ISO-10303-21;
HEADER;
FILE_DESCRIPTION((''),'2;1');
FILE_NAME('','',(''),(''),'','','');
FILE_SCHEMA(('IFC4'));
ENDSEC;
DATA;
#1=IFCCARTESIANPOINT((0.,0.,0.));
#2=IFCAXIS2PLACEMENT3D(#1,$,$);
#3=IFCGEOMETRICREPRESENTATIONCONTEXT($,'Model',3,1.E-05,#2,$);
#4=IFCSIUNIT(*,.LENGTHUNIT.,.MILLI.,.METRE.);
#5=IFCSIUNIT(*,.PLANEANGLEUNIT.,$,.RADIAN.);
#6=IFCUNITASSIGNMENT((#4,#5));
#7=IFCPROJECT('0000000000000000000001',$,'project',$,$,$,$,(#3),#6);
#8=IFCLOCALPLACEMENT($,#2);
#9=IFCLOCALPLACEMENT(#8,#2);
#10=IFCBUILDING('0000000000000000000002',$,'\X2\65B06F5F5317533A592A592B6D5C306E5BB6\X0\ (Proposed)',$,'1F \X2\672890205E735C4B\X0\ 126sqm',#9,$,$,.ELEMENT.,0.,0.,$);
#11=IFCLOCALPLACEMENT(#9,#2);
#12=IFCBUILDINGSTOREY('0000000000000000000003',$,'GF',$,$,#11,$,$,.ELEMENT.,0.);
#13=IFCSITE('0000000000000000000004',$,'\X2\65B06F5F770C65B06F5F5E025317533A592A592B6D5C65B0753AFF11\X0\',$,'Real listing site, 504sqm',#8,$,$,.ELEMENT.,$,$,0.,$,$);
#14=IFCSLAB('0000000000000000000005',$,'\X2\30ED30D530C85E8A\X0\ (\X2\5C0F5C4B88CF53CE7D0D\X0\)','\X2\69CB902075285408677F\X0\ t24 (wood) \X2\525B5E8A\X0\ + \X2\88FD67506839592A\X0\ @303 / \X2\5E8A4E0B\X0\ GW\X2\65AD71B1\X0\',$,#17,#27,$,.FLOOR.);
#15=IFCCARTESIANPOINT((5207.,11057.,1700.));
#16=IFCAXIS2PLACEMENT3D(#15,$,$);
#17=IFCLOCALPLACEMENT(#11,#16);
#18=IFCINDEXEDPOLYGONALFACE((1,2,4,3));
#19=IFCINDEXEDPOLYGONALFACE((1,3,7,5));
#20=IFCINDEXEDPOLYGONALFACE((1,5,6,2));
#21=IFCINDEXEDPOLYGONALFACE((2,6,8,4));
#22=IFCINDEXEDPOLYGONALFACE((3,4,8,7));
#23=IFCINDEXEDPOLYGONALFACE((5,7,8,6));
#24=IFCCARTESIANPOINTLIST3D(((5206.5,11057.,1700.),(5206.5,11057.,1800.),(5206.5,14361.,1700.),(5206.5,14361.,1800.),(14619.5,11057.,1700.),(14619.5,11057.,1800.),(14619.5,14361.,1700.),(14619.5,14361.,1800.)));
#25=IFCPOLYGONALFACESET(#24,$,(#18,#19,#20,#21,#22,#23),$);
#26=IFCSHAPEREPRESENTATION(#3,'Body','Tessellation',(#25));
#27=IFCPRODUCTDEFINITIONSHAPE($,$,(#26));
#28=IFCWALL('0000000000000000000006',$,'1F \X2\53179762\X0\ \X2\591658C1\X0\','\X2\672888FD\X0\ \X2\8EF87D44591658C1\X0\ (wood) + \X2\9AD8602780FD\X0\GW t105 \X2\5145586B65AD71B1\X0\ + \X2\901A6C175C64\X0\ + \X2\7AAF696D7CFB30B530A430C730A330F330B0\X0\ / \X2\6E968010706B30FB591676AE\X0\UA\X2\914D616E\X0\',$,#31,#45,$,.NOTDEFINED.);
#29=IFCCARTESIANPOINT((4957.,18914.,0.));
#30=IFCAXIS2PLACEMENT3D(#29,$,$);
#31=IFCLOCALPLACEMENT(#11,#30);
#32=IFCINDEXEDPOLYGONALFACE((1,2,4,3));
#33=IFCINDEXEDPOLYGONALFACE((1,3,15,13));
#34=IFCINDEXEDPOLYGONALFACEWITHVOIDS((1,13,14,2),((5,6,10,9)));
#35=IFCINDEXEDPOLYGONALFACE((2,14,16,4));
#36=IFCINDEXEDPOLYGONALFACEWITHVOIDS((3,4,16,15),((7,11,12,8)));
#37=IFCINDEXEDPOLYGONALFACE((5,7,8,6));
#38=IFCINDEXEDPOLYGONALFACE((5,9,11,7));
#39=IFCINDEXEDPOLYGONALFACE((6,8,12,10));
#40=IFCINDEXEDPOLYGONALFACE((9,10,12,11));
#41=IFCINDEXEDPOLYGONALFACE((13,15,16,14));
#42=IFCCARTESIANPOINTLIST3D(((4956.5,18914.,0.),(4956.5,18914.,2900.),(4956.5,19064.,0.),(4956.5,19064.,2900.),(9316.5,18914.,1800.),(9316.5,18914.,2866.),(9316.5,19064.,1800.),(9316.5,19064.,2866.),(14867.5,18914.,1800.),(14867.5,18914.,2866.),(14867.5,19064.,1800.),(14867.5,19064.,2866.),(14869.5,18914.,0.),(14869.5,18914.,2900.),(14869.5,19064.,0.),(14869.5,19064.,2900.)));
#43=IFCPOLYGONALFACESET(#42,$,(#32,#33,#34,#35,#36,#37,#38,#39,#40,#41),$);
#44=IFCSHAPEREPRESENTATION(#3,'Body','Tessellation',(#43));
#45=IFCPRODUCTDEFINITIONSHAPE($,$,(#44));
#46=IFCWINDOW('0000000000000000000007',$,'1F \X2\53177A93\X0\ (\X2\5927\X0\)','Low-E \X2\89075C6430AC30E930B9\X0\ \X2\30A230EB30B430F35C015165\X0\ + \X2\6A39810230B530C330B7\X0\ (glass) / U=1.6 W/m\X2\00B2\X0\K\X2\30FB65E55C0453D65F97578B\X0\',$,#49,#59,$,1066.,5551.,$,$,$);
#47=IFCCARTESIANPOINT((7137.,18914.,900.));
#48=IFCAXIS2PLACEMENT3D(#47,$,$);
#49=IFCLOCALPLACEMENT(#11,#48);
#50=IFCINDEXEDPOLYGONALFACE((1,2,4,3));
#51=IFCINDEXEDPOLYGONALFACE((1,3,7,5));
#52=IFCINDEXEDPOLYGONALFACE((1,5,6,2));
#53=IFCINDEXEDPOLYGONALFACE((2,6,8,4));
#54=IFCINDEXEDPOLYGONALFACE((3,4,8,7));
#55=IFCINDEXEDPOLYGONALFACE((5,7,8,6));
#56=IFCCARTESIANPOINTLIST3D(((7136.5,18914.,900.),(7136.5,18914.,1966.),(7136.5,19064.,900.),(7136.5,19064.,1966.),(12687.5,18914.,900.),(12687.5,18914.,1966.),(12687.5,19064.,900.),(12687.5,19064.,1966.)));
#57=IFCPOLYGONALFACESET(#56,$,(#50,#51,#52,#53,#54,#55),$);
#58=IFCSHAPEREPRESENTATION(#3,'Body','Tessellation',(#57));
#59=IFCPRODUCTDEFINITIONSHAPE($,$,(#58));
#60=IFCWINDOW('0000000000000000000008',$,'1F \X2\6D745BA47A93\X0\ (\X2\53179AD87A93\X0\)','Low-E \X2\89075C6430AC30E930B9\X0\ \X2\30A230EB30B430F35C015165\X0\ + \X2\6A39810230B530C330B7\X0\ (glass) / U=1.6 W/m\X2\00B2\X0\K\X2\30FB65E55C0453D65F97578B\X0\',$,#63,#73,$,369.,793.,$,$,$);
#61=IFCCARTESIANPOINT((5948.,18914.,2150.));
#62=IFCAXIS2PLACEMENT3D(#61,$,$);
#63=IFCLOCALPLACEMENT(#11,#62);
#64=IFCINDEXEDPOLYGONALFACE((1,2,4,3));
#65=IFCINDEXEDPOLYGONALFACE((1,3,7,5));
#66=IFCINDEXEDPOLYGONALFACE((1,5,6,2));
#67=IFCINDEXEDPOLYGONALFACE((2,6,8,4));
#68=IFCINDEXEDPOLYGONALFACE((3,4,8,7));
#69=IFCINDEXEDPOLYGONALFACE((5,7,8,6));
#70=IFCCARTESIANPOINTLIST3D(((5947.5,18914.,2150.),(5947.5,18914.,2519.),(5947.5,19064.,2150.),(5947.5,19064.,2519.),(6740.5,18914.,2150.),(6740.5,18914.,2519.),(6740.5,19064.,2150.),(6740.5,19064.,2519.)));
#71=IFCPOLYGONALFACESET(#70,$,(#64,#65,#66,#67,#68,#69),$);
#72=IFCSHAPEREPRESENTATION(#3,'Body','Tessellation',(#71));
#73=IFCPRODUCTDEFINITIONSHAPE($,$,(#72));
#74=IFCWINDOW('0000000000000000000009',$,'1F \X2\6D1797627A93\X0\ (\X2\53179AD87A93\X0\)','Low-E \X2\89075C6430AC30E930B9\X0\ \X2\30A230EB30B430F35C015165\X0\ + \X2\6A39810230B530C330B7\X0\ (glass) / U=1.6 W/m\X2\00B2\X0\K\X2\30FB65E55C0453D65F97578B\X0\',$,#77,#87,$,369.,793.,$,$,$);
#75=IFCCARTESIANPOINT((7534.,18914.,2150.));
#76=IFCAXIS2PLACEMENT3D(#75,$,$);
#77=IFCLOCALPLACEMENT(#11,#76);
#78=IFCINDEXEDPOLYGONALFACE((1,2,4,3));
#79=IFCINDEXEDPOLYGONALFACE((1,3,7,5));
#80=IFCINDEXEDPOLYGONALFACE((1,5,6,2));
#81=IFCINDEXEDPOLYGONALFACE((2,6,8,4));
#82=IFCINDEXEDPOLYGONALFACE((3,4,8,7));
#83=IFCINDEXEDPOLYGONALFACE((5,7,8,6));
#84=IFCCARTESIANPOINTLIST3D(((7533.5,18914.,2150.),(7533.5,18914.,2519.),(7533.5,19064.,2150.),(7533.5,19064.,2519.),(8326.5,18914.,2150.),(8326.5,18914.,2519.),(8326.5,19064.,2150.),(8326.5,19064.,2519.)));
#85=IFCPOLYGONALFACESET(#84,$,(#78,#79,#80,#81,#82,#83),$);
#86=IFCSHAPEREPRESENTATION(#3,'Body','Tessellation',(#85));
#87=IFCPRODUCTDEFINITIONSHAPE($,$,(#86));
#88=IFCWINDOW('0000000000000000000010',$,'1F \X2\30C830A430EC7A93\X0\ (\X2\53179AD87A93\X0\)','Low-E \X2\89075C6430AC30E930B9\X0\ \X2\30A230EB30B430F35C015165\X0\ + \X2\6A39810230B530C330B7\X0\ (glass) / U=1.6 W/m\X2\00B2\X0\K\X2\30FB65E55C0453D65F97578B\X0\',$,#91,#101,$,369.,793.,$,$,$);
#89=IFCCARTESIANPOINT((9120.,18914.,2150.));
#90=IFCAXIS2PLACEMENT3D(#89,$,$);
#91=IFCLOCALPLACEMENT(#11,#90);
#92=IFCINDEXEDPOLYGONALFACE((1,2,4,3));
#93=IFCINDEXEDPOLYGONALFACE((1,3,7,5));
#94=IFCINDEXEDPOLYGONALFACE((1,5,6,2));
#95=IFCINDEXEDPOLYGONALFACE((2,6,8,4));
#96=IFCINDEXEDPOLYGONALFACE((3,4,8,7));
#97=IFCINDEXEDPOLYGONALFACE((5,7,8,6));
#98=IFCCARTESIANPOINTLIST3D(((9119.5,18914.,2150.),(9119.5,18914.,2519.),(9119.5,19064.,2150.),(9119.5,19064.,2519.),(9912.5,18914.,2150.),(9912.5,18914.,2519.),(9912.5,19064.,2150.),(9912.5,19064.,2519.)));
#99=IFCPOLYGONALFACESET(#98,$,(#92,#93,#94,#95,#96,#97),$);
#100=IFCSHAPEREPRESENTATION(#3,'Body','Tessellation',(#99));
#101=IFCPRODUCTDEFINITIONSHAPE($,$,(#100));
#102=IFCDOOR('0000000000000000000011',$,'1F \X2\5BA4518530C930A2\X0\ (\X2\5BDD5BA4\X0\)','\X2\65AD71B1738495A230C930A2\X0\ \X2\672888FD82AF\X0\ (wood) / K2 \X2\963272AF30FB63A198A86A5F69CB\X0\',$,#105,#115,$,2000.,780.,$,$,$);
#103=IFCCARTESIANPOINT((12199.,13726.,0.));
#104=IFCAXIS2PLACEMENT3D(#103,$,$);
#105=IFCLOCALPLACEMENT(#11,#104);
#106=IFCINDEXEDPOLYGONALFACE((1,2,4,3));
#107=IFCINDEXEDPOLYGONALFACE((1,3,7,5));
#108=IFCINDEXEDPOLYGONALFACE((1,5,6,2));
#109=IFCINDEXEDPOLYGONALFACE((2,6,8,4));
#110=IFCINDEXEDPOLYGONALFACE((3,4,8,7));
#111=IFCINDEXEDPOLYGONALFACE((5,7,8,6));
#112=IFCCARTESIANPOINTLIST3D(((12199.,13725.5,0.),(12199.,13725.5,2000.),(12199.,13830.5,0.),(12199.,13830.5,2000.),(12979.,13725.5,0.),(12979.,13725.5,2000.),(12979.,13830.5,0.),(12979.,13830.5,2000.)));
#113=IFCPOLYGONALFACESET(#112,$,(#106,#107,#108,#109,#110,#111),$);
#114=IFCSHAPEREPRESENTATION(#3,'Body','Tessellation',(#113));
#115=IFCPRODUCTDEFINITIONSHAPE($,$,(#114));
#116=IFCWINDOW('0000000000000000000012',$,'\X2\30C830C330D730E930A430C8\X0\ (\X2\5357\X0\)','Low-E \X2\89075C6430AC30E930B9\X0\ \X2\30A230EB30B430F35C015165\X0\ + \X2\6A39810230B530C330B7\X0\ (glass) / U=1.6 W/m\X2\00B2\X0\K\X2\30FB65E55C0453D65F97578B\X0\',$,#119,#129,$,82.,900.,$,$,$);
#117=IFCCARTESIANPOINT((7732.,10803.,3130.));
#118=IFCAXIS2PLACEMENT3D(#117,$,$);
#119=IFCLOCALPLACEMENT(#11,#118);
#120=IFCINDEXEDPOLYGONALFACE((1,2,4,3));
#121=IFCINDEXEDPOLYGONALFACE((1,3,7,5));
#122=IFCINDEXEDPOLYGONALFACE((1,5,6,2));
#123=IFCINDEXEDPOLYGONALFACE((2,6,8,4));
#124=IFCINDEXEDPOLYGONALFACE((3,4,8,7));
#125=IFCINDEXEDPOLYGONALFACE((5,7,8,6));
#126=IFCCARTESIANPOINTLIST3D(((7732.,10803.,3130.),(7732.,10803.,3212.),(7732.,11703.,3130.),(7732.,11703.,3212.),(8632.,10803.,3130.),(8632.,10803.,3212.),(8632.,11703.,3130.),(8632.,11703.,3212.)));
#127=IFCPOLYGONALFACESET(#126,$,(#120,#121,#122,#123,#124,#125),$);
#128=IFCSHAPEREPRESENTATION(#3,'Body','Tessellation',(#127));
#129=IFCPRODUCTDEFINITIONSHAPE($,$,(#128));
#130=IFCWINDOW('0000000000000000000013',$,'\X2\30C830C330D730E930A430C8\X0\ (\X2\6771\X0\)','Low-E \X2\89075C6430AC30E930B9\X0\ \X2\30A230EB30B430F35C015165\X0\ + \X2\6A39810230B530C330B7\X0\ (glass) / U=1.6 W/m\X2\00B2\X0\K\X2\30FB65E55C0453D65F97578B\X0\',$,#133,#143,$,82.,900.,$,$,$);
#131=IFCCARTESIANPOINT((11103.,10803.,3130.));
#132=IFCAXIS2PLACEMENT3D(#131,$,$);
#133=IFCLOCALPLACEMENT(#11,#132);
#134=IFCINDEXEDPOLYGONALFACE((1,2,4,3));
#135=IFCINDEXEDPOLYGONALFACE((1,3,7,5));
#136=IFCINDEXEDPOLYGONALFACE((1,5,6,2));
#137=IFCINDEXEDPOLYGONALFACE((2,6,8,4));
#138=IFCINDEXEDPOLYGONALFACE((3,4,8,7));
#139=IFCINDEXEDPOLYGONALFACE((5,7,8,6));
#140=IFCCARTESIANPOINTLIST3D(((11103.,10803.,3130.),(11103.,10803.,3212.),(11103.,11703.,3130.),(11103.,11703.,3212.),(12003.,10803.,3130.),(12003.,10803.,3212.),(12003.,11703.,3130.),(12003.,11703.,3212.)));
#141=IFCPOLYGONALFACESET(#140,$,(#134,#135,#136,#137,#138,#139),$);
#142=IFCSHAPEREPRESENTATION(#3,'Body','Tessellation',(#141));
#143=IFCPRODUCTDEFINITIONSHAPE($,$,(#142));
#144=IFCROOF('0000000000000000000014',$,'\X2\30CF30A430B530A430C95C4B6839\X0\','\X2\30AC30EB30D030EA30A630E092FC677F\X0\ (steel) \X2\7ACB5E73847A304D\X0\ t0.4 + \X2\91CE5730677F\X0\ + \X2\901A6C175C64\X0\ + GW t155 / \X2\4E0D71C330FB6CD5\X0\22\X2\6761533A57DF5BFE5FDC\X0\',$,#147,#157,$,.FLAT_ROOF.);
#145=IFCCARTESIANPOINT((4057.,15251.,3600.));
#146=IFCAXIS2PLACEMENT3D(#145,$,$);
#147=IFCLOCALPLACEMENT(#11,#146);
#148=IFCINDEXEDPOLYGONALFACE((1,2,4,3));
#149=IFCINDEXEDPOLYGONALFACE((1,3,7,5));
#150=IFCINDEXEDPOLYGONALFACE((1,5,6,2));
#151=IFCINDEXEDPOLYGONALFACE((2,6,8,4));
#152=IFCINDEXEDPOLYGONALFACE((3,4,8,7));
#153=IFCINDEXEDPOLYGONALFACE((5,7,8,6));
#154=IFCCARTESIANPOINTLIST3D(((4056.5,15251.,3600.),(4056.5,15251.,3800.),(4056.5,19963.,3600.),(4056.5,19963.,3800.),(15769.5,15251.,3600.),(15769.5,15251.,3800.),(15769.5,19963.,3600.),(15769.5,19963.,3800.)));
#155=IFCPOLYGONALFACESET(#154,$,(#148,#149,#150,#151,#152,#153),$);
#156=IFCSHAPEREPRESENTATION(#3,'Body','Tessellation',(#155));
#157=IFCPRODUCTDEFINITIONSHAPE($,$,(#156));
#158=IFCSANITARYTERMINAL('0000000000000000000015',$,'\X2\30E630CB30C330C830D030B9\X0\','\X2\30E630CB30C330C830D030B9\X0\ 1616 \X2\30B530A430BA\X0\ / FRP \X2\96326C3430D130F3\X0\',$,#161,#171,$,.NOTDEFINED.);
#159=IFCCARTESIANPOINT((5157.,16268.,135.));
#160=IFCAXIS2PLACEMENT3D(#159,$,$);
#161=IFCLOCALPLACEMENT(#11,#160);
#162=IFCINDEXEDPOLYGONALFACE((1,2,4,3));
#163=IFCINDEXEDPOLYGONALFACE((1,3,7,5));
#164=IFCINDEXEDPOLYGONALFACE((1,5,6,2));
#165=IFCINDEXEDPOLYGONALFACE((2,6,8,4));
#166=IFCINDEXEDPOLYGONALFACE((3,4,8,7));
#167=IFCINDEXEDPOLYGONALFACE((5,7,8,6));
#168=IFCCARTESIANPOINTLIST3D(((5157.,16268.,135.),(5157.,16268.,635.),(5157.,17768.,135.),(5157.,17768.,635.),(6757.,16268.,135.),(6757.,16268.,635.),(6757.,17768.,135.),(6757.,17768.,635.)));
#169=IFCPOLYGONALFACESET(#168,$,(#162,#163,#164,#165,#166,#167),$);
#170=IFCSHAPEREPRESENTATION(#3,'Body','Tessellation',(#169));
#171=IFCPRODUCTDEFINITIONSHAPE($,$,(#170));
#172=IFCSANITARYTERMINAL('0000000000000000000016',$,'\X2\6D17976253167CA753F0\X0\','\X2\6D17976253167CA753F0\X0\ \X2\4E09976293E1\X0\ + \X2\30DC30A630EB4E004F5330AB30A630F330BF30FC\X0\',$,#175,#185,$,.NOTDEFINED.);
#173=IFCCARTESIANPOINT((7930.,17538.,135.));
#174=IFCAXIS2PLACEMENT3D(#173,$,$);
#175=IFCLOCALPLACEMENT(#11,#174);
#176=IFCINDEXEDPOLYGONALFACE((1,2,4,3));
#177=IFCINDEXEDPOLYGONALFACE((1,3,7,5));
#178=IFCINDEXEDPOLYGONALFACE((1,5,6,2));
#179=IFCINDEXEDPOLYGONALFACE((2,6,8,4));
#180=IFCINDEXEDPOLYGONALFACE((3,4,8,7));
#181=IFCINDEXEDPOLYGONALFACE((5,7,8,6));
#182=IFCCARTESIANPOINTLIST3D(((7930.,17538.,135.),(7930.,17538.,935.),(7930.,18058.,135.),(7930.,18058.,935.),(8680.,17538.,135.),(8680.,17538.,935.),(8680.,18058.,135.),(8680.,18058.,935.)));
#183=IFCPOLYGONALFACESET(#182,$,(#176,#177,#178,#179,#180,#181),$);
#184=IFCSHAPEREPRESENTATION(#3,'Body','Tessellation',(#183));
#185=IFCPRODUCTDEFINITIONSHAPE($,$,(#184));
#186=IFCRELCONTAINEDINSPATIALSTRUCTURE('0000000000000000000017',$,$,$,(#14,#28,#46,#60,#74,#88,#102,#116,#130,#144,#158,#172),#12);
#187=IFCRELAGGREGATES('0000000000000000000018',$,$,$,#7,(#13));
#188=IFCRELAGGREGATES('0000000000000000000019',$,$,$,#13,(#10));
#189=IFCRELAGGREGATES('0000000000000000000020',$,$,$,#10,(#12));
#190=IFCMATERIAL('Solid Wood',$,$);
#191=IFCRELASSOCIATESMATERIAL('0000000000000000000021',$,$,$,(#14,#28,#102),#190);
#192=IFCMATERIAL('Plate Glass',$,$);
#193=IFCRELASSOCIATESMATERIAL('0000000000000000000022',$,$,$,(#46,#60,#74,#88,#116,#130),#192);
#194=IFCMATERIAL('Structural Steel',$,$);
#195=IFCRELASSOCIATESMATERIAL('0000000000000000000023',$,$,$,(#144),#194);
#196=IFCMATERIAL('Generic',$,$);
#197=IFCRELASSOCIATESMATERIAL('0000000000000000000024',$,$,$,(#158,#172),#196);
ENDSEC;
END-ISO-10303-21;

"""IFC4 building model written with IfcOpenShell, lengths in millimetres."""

from ifc_helpers import new_model, si_unit, frame, frame_2d, origin, place, context, project, spatial, rectangle, extrude, material, element, fill, save


model = new_model("IFC4")

# Units and contexts
model_context = context("Model", 3, precision=1e-05, world=origin())
ifc_project = project(units=[si_unit("LENGTHUNIT", "METRE", prefix="MILLI"), si_unit("PLANEANGLEUNIT", "RADIAN")], contexts=[model_context])

# Site, building, storey
site_placement = place(None, origin())
site = spatial("IfcSite", under=ifc_project, at=site_placement, Name="新潟県新潟市北区太夫浜新町１", ObjectType="Real listing site, 504sqm", CompositionType="ELEMENT", RefElevation=0.0)
building_placement = place(site_placement, origin())
building = spatial("IfcBuilding", under=site, at=building_placement, Name="新潟北区太夫浜の家 (Proposed)", ObjectType="1F 木造平屋 126sqm", CompositionType="ELEMENT", ElevationOfRefHeight=0.0, ElevationOfTerrain=0.0)
storey_placement = place(building_placement, origin())
storey = spatial("IfcBuildingStorey", under=building, at=storey_placement, Name="GF", CompositionType="ELEMENT", Elevation=0.0)

# Slab
ifc_material_1 = material(Name="Solid Wood")
slab_placement = place(storey_placement, frame((5207.0, 11057.0, 1700.0)))
element("IfcSlab", 1, at=slab_placement, inside=storey, material=ifc_material_1, Name="ロフト床 (小屋裏収納)", Description="構造用合板 t24 (wood) 剛床 + 製材根太 @303 / 床下 GW断熱", PredefinedType="FLOOR", context=model_context, shape_type="SweptSolid", body=[
    extrude(rectangle(XDim=9413.0, YDim=3304.0, at=frame_2d((4706.0, 1652.0))), frame((5207.0, 11057.0, 1700.0)), (0.0, 0.0, 1.0), 100.0),
])

# Wall, openings, windows
wall_1_placement = place(storey_placement, frame((4957.0, 18914.0, 0.0)))
wall_1 = element("IfcWall", 2, at=wall_1_placement, inside=storey, material=ifc_material_1, Name="1F 北面 外壁", Description="木製 軸組外壁 (wood) + 高性能GW t105 充填断熱 + 通気層 + 窯業系サイディング / 準耐火・外皮UA配慮", PredefinedType="NOTDEFINED", context=model_context, shape_type="SweptSolid", body=[
    extrude(rectangle(XDim=9913.0, YDim=150.0, at=frame_2d((4956.0, 75.0))), frame((4957.0, 18914.0, 0.0)), (0.0, 0.0, 1.0), 2900.0),
])
opening_1_placement = place(storey_placement, frame((7137.0, 18914.0, 900.0)))
opening_1 = element("IfcOpeningElement", 3, at=opening_1_placement, cuts=wall_1, PredefinedType="NOTDEFINED", context=model_context, shape_type="SweptSolid", body=[
    extrude(rectangle(XDim=5551.0, YDim=150.0, at=frame_2d((2775.0, 75.0))), frame((7137.0, 18914.0, 900.0)), (0.0, 0.0, 1.0), 1066.0),
])
opening_2_placement = place(storey_placement, frame((5948.0, 18914.0, 2150.0)))
opening_2 = element("IfcOpeningElement", 4, at=opening_2_placement, cuts=wall_1, PredefinedType="NOTDEFINED", context=model_context, shape_type="SweptSolid", body=[
    extrude(rectangle(XDim=793.0, YDim=150.0, at=frame_2d((396.0, 75.0))), frame((5948.0, 18914.0, 2150.0)), (0.0, 0.0, 1.0), 369.0),
])
opening_3_placement = place(storey_placement, frame((7534.0, 18914.0, 2150.0)))
opening_3 = element("IfcOpeningElement", 5, at=opening_3_placement, cuts=wall_1, PredefinedType="NOTDEFINED", context=model_context, shape_type="SweptSolid", body=[
    extrude(rectangle(XDim=793.0, YDim=150.0, at=frame_2d((396.0, 75.0))), frame((7534.0, 18914.0, 2150.0)), (0.0, 0.0, 1.0), 369.0),
])
opening_4_placement = place(storey_placement, frame((9120.0, 18914.0, 2150.0)))
opening_4 = element("IfcOpeningElement", 6, at=opening_4_placement, cuts=wall_1, PredefinedType="NOTDEFINED", context=model_context, shape_type="SweptSolid", body=[
    extrude(rectangle(XDim=793.0, YDim=150.0, at=frame_2d((396.0, 75.0))), frame((9120.0, 18914.0, 2150.0)), (0.0, 0.0, 1.0), 369.0),
])
ifc_material_2 = material(Name="Plate Glass")
window_1_placement = place(storey_placement, frame((7137.0, 18914.0, 900.0)))
window_1 = element("IfcWindow", 7, at=window_1_placement, inside=storey, material=ifc_material_2, Name="1F 北窓 (大)", Description="Low-E 複層ガラス アルゴン封入 + 樹脂サッシ (glass) / U=1.6 W/m²K・日射取得型", OverallHeight=1066.0, OverallWidth=5551.0, context=model_context, shape_type="SweptSolid", body=[
    extrude(rectangle(XDim=5551.0, YDim=150.0, at=frame_2d((2775.0, 75.0))), frame((7137.0, 18914.0, 900.0)), (0.0, 0.0, 1.0), 1066.0),
])
fill(opening_1, window_1)
window_2_placement = place(storey_placement, frame((5948.0, 18914.0, 2150.0)))
window_2 = element("IfcWindow", 8, at=window_2_placement, inside=storey, material=ifc_material_2, Name="1F 浴室窓 (北高窓)", Description="Low-E 複層ガラス アルゴン封入 + 樹脂サッシ (glass) / U=1.6 W/m²K・日射取得型", OverallHeight=369.0, OverallWidth=793.0, context=model_context, shape_type="SweptSolid", body=[
    extrude(rectangle(XDim=793.0, YDim=150.0, at=frame_2d((396.0, 75.0))), frame((5948.0, 18914.0, 2150.0)), (0.0, 0.0, 1.0), 369.0),
])
fill(opening_2, window_2)
window_3_placement = place(storey_placement, frame((7534.0, 18914.0, 2150.0)))
window_3 = element("IfcWindow", 9, at=window_3_placement, inside=storey, material=ifc_material_2, Name="1F 洗面窓 (北高窓)", Description="Low-E 複層ガラス アルゴン封入 + 樹脂サッシ (glass) / U=1.6 W/m²K・日射取得型", OverallHeight=369.0, OverallWidth=793.0, context=model_context, shape_type="SweptSolid", body=[
    extrude(rectangle(XDim=793.0, YDim=150.0, at=frame_2d((396.0, 75.0))), frame((7534.0, 18914.0, 2150.0)), (0.0, 0.0, 1.0), 369.0),
])
fill(opening_3, window_3)
window_4_placement = place(storey_placement, frame((9120.0, 18914.0, 2150.0)))
window_4 = element("IfcWindow", 10, at=window_4_placement, inside=storey, material=ifc_material_2, Name="1F トイレ窓 (北高窓)", Description="Low-E 複層ガラス アルゴン封入 + 樹脂サッシ (glass) / U=1.6 W/m²K・日射取得型", OverallHeight=369.0, OverallWidth=793.0, context=model_context, shape_type="SweptSolid", body=[
    extrude(rectangle(XDim=793.0, YDim=150.0, at=frame_2d((396.0, 75.0))), frame((9120.0, 18914.0, 2150.0)), (0.0, 0.0, 1.0), 369.0),
])
fill(opening_4, window_4)

# Door
door_1_placement = place(storey_placement, frame((12199.0, 13726.0, 0.0)))
element("IfcDoor", 11, at=door_1_placement, inside=storey, material=ifc_material_1, Name="1F 室内ドア (寝室)", Description="断熱玄関ドア 木製芯 (wood) / K2 防犯・採風機構", OverallHeight=2000.0, OverallWidth=780.0, context=model_context, shape_type="SweptSolid", body=[
    extrude(rectangle(XDim=780.0, YDim=105.0, at=frame_2d((390.0, 52.0))), frame((12199.0, 13726.0, 0.0)), (0.0, 0.0, 1.0), 2000.0),
])

# Windows
window_5_placement = place(storey_placement, frame((7732.0, 10803.0, 3130.0)))
element("IfcWindow", 12, at=window_5_placement, inside=storey, material=ifc_material_2, Name="トップライト (南)", Description="Low-E 複層ガラス アルゴン封入 + 樹脂サッシ (glass) / U=1.6 W/m²K・日射取得型", OverallHeight=82.0, OverallWidth=900.0, context=model_context, shape_type="SweptSolid", body=[
    extrude(rectangle(XDim=900.0, YDim=900.0, at=frame_2d((450.0, 450.0))), frame((7732.0, 10803.0, 3130.0)), (0.0, 0.0, 1.0), 82.0),
])
window_6_placement = place(storey_placement, frame((11103.0, 10803.0, 3130.0)))
element("IfcWindow", 13, at=window_6_placement, inside=storey, material=ifc_material_2, Name="トップライト (東)", Description="Low-E 複層ガラス アルゴン封入 + 樹脂サッシ (glass) / U=1.6 W/m²K・日射取得型", OverallHeight=82.0, OverallWidth=900.0, context=model_context, shape_type="SweptSolid", body=[
    extrude(rectangle(XDim=900.0, YDim=900.0, at=frame_2d((450.0, 450.0))), frame((11103.0, 10803.0, 3130.0)), (0.0, 0.0, 1.0), 82.0),
])

# Roof
ifc_material_3 = material(Name="Structural Steel")
roof_placement = place(storey_placement, frame((4057.0, 15251.0, 3600.0)))
element("IfcRoof", 14, at=roof_placement, inside=storey, material=ifc_material_3, Name="ハイサイド屋根", Description="ガルバリウム鋼板 (steel) 立平葺き t0.4 + 野地板 + 通気層 + GW t155 / 不燃・法22条区域対応", PredefinedType="FLAT_ROOF", context=model_context, shape_type="SweptSolid", body=[
    extrude(rectangle(XDim=11713.0, YDim=4712.0, at=frame_2d((5856.0, 2356.0))), frame((4057.0, 15251.0, 3600.0)), (0.0, 0.0, 1.0), 200.0),
])

# Sanitary terminals
ifc_material_4 = material(Name="Generic")
sanitary_terminal_1_placement = place(storey_placement, frame((5157.0, 16268.0, 135.0)))
element("IfcSanitaryTerminal", 15, at=sanitary_terminal_1_placement, inside=storey, material=ifc_material_4, Name="ユニットバス", Description="ユニットバス 1616 サイズ / FRP 防水パン", PredefinedType="NOTDEFINED", context=model_context, shape_type="SweptSolid", body=[
    extrude(rectangle(XDim=1600.0, YDim=1500.0, at=frame_2d((800.0, 750.0))), frame((5157.0, 16268.0, 135.0)), (0.0, 0.0, 1.0), 500.0),
])
sanitary_terminal_2_placement = place(storey_placement, frame((7930.0, 17538.0, 135.0)))
element("IfcSanitaryTerminal", 16, at=sanitary_terminal_2_placement, inside=storey, material=ifc_material_4, Name="洗面化粧台", Description="洗面化粧台 三面鏡 + ボウル一体カウンター", PredefinedType="NOTDEFINED", context=model_context, shape_type="SweptSolid", body=[
    extrude(rectangle(XDim=750.0, YDim=520.0, at=frame_2d((375.0, 260.0))), frame((7930.0, 17538.0, 135.0)), (0.0, 0.0, 1.0), 800.0),
])

save(model, "model.ifc")
